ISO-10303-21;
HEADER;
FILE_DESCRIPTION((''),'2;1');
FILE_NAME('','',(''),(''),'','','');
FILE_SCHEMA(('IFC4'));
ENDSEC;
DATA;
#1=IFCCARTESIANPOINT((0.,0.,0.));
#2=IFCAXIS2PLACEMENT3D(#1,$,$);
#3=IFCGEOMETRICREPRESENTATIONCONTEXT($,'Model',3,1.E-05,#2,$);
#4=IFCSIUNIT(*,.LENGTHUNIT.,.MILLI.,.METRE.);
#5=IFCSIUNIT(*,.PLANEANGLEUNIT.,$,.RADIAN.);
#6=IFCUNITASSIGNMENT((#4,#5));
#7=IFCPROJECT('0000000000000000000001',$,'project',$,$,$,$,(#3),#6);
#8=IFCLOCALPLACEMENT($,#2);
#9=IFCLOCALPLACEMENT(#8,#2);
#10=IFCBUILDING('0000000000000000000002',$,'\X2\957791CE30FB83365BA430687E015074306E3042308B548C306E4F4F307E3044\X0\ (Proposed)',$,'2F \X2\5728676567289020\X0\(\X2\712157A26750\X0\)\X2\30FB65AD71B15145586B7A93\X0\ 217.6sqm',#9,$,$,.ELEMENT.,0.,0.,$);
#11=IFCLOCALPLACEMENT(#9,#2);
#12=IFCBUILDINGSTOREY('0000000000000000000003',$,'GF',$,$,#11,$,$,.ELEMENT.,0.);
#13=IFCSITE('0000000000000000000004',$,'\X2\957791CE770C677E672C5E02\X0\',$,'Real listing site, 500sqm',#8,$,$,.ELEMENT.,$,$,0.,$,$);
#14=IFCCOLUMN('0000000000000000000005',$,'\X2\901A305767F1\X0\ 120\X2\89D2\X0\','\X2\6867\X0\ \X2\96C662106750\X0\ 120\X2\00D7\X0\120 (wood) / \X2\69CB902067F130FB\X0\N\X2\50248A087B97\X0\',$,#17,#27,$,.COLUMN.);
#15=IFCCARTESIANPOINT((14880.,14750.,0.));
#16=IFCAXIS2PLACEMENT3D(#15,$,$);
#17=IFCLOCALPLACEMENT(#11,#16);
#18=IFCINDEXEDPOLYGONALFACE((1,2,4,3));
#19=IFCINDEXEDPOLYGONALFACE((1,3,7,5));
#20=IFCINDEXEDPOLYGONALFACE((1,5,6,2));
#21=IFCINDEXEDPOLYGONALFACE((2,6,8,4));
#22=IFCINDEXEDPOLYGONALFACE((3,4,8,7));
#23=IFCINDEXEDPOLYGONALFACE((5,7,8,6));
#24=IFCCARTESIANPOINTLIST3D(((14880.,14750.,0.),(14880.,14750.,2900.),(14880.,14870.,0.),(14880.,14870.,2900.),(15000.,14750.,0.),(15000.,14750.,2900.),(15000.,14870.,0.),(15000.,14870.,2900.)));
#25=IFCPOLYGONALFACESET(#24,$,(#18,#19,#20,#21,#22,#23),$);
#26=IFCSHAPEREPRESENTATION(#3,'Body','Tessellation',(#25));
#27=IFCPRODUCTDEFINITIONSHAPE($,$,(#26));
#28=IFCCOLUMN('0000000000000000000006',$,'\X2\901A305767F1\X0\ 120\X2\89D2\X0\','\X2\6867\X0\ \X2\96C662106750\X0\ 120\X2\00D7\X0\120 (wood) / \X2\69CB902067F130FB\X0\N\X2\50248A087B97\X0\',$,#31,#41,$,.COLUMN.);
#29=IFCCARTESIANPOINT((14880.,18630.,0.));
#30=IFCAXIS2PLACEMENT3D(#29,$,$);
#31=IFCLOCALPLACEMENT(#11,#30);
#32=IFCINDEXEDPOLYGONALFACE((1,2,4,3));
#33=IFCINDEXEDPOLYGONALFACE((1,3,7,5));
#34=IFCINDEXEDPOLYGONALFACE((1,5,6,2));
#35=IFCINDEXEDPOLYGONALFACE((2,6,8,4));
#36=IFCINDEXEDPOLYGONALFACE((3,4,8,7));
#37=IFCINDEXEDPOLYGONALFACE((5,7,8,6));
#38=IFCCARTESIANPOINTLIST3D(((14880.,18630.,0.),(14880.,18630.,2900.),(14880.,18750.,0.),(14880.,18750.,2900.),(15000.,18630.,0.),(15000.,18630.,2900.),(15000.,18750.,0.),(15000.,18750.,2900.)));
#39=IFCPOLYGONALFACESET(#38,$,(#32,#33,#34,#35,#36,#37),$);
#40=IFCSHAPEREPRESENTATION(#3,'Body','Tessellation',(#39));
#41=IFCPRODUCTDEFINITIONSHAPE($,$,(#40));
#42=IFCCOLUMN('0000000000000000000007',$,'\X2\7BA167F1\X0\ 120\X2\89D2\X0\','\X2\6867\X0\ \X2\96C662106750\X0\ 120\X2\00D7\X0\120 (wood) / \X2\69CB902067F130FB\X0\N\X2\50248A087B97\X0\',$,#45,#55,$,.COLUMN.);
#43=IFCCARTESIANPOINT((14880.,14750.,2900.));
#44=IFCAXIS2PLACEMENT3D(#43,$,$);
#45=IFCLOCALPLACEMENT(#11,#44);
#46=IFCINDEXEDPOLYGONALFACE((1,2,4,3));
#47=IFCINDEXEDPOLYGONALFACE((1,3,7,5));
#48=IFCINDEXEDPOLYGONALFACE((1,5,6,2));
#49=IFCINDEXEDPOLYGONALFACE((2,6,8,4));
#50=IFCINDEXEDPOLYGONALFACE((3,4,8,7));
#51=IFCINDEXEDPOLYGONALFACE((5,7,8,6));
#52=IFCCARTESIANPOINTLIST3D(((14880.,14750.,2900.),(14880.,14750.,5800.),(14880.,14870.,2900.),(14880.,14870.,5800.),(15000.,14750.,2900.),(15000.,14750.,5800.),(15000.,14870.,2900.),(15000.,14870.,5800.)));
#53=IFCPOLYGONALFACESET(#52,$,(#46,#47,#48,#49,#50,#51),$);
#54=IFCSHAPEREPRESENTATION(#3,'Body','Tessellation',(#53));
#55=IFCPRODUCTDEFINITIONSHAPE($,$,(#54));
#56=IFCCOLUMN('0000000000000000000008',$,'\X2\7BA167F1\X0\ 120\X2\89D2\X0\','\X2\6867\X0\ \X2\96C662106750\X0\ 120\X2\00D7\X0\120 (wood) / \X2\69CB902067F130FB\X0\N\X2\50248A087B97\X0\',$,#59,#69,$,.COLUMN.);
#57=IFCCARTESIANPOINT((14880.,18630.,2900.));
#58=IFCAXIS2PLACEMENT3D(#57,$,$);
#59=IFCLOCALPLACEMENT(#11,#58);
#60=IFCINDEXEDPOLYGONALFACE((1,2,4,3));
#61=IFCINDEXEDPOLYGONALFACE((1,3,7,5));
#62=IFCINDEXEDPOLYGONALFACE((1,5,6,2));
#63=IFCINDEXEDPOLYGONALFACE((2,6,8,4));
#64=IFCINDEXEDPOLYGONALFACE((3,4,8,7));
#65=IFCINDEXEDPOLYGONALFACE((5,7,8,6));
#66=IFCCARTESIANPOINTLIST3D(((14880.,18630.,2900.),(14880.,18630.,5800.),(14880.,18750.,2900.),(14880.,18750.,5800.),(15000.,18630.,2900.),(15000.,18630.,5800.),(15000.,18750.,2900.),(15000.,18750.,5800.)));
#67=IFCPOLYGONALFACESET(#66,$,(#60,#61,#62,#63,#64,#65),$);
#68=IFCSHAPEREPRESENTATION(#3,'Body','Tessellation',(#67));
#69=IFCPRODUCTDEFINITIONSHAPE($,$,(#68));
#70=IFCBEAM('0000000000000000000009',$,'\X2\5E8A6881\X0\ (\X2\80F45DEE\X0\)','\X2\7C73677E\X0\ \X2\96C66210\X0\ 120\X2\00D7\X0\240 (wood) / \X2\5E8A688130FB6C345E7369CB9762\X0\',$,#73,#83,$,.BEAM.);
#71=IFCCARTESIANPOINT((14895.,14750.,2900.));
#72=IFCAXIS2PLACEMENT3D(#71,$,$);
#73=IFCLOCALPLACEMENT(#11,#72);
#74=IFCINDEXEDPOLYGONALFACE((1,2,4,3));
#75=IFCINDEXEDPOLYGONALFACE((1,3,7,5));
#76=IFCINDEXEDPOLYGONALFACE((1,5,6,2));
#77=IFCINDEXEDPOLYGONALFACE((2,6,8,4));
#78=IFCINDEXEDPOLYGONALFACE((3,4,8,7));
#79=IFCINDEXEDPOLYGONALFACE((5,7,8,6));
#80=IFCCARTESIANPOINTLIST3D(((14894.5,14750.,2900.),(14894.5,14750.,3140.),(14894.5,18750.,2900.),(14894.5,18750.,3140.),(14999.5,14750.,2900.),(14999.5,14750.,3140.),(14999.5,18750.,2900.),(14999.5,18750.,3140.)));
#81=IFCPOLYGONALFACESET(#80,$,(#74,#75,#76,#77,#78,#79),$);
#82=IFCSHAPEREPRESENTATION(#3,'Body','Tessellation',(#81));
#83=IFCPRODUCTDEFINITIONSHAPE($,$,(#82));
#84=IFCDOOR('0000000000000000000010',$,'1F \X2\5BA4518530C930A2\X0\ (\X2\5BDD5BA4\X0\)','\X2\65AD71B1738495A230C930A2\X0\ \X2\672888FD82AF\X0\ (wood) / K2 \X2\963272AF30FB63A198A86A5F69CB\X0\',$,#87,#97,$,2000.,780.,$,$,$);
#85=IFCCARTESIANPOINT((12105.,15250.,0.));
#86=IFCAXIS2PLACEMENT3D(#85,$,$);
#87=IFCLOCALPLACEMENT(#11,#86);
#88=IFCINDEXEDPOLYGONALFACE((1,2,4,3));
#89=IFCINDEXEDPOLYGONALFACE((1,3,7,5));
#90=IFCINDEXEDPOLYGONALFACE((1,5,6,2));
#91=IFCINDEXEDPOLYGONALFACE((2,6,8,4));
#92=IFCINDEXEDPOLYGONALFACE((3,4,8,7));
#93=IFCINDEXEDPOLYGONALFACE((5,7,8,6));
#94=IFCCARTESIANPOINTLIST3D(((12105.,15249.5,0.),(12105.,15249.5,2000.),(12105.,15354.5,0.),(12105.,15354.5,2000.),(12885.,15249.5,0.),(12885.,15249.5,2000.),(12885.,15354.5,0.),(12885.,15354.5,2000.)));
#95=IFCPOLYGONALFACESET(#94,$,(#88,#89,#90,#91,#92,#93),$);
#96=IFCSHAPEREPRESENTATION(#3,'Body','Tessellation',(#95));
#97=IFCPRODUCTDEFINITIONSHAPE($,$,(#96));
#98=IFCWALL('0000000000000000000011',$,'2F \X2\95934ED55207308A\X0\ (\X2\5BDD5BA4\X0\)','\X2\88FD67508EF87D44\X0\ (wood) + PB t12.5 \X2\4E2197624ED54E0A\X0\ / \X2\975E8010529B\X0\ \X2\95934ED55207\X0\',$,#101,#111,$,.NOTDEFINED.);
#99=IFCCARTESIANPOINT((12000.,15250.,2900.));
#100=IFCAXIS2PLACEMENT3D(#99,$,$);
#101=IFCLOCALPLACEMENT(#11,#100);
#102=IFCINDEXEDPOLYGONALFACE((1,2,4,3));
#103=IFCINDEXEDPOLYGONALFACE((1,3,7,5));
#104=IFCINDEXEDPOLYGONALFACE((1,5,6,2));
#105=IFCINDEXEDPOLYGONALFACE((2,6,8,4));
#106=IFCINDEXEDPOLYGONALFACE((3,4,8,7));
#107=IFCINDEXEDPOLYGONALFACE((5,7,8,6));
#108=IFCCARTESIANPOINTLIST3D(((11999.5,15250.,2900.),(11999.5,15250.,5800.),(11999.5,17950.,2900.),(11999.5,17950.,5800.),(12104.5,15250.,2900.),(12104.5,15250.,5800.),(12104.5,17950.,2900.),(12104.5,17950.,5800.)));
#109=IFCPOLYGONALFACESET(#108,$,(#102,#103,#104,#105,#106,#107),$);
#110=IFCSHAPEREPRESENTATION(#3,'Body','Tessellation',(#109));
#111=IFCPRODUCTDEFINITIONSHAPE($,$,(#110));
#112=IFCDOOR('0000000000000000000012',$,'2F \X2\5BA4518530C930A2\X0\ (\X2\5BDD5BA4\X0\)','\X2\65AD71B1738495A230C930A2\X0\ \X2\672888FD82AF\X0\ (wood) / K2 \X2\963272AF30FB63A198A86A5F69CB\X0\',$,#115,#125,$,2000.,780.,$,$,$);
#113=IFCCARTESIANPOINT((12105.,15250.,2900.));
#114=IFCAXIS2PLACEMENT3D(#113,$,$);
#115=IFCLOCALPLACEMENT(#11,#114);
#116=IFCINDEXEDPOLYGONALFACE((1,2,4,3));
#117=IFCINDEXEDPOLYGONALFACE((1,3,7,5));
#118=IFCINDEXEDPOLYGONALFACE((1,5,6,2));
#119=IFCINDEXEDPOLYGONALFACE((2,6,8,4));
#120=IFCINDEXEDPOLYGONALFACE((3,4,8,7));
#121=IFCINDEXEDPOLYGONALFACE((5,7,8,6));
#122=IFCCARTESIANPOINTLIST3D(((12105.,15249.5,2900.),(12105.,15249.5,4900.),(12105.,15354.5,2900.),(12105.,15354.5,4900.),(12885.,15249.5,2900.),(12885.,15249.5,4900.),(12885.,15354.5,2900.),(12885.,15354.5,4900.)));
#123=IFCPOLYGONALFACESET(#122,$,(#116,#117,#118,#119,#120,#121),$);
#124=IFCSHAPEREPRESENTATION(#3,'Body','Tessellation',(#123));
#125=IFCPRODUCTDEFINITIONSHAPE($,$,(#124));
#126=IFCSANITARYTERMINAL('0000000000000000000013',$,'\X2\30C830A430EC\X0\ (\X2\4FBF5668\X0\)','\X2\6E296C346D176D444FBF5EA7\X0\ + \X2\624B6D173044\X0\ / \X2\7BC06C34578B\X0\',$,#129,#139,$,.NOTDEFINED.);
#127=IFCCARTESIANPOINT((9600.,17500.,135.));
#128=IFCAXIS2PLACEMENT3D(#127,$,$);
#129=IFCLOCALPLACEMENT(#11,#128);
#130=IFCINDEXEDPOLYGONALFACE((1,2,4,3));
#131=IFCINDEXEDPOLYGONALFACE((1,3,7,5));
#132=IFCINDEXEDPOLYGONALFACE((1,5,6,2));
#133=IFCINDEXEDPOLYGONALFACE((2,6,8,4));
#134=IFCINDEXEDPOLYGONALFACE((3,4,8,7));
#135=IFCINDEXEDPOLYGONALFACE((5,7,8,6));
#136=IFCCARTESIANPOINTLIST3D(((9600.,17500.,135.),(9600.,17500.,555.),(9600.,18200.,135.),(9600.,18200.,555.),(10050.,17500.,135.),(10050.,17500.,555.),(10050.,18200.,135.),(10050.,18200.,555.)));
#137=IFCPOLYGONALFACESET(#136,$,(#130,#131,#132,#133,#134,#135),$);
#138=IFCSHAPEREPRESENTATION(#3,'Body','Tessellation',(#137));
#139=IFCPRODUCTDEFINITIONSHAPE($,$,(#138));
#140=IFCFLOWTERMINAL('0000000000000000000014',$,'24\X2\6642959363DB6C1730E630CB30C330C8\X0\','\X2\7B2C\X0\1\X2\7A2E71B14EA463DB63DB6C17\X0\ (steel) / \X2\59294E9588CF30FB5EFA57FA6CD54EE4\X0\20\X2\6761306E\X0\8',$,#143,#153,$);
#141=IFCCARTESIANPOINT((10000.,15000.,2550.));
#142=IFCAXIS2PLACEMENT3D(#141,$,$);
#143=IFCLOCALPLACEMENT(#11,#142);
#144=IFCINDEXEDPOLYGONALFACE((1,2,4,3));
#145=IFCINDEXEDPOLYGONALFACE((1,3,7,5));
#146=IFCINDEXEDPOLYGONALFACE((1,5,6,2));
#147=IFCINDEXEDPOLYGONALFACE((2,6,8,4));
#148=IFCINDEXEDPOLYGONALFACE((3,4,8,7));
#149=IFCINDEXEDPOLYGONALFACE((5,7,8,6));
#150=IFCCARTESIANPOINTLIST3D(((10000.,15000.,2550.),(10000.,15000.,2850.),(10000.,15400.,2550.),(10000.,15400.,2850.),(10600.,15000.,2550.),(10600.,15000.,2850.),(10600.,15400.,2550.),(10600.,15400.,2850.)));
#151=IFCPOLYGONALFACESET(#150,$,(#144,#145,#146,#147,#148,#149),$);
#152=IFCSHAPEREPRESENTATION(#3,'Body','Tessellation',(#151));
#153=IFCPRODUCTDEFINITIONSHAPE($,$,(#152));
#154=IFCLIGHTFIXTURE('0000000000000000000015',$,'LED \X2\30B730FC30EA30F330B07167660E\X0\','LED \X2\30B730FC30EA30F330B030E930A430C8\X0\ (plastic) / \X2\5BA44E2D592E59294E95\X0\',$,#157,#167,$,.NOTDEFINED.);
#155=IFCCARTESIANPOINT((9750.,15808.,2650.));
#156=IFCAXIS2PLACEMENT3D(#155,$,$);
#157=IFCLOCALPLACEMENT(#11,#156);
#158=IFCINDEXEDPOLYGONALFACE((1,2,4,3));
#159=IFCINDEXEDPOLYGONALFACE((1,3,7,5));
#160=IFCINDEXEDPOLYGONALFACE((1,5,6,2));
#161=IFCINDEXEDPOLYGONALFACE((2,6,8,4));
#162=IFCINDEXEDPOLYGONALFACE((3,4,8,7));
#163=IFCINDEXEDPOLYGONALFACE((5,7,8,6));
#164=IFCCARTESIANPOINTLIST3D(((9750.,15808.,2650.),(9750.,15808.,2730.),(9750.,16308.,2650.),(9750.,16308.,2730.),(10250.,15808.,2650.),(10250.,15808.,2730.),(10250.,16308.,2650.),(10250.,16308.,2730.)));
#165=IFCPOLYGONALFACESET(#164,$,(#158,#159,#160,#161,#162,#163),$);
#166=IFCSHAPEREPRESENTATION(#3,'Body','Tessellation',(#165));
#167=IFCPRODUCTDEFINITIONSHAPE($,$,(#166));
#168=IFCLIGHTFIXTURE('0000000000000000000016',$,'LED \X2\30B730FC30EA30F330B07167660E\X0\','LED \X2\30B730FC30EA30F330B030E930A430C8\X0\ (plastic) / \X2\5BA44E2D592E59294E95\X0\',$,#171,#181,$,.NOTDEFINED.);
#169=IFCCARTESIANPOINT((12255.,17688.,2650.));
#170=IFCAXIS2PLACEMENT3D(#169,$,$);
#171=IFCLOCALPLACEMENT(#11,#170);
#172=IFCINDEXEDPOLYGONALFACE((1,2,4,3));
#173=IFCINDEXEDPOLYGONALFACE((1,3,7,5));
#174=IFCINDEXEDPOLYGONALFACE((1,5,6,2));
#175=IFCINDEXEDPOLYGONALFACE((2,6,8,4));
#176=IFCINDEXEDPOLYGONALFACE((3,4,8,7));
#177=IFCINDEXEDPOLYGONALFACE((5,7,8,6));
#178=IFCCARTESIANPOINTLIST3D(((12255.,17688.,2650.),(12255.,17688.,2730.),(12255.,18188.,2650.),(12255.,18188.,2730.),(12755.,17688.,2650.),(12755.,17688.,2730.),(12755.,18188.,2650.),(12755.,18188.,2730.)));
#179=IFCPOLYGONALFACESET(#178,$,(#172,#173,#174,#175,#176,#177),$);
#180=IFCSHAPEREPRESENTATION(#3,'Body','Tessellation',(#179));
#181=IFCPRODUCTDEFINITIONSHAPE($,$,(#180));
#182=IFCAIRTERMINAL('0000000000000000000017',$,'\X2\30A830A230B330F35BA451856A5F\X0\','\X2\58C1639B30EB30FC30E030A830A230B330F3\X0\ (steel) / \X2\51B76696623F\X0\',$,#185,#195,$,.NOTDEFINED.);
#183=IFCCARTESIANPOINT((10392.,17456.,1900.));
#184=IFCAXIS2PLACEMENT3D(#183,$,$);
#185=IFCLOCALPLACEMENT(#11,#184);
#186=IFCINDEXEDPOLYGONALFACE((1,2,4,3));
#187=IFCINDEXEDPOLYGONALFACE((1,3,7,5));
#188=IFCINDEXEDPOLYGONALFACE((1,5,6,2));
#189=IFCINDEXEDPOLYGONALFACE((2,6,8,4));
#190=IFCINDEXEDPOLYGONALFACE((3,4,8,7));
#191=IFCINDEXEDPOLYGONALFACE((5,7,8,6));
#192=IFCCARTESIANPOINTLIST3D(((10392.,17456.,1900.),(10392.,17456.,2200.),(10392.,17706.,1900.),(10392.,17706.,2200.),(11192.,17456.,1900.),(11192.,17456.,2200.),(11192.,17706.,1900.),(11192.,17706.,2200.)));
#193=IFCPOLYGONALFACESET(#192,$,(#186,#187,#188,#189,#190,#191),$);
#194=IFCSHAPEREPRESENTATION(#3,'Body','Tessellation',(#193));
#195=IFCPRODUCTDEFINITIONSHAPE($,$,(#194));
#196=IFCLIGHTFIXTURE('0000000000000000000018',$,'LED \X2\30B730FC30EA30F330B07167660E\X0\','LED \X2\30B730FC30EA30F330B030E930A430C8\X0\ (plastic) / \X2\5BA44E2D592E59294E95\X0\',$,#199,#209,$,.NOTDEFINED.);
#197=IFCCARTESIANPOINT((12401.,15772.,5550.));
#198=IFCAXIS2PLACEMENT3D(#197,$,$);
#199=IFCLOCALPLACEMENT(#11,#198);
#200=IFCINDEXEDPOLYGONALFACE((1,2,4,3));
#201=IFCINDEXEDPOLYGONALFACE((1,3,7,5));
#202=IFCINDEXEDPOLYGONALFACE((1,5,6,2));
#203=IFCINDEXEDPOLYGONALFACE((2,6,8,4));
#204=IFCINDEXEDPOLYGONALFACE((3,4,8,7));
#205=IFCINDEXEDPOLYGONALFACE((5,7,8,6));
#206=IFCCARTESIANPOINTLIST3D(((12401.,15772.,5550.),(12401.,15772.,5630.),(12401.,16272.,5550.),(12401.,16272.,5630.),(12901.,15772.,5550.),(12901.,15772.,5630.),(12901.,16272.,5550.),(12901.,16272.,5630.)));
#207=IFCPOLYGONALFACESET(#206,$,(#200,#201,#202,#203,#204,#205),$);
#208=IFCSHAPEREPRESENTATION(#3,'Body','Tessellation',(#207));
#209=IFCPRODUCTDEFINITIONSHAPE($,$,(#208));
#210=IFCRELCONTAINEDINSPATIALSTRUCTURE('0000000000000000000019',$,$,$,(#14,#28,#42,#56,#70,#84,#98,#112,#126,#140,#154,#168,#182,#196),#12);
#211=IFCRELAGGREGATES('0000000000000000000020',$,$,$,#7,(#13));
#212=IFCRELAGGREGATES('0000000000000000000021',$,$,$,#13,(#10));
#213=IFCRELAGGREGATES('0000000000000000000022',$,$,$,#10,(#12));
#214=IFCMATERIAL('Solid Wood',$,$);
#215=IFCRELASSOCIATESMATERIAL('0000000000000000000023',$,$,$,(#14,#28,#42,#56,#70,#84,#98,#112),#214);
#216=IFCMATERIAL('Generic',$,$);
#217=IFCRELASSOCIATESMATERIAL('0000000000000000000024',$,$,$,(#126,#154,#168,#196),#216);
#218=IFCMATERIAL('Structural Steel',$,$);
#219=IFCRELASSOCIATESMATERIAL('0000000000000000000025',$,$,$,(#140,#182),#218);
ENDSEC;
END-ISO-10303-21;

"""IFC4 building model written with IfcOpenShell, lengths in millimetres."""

from ifc_helpers import new_model, si_unit, frame, frame_2d, origin, place, context, project, spatial, rectangle, extrude, material, element, save


model = new_model("IFC4")

# Units and contexts
model_context = context("Model", 3, precision=1e-05, world=origin())
ifc_project = project(units=[si_unit("LENGTHUNIT", "METRE", prefix="MILLI"), si_unit("PLANEANGLEUNIT", "RADIAN")], contexts=[model_context])

# Site, building, storey
site_placement = place(None, origin())
site = spatial("IfcSite", under=ifc_project, at=site_placement, Name="長野県松本市", ObjectType="Real listing site, 500sqm", CompositionType="ELEMENT", RefElevation=0.0)
building_placement = place(site_placement, origin())
building = spatial("IfcBuilding", under=site, at=building_placement, Name="長野・茶室と縁側のある和の住まい (Proposed)", ObjectType="2F 在来木造(無垢材)・断熱充填窓 217.6sqm", CompositionType="ELEMENT", ElevationOfRefHeight=0.0, ElevationOfTerrain=0.0)
storey_placement = place(building_placement, origin())
storey = spatial("IfcBuildingStorey", under=building, at=storey_placement, Name="GF", CompositionType="ELEMENT", Elevation=0.0)

# Columns
ifc_material_1 = material(Name="Solid Wood")
column_1_placement = place(storey_placement, frame((14880.0, 14750.0, 0.0)))
element("IfcColumn", 1, at=column_1_placement, inside=storey, material=ifc_material_1, Name="通し柱 120角", Description="桧 集成材 120×120 (wood) / 構造柱・N値計算", PredefinedType="COLUMN", context=model_context, shape_type="SweptSolid", body=[
    extrude(rectangle(XDim=120.0, YDim=120.0, at=frame_2d((60.0, 60.0))), frame((14880.0, 14750.0, 0.0)), (0.0, 0.0, 1.0), 2900.0),
])
column_2_placement = place(storey_placement, frame((14880.0, 18630.0, 0.0)))
element("IfcColumn", 2, at=column_2_placement, inside=storey, material=ifc_material_1, Name="通し柱 120角", Description="桧 集成材 120×120 (wood) / 構造柱・N値計算", PredefinedType="COLUMN", context=model_context, shape_type="SweptSolid", body=[
    extrude(rectangle(XDim=120.0, YDim=120.0, at=frame_2d((60.0, 60.0))), frame((14880.0, 18630.0, 0.0)), (0.0, 0.0, 1.0), 2900.0),
])
column_3_placement = place(storey_placement, frame((14880.0, 14750.0, 2900.0)))
element("IfcColumn", 3, at=column_3_placement, inside=storey, material=ifc_material_1, Name="管柱 120角", Description="桧 集成材 120×120 (wood) / 構造柱・N値計算", PredefinedType="COLUMN", context=model_context, shape_type="SweptSolid", body=[
    extrude(rectangle(XDim=120.0, YDim=120.0, at=frame_2d((60.0, 60.0))), frame((14880.0, 14750.0, 2900.0)), (0.0, 0.0, 1.0), 2900.0),
])
column_4_placement = place(storey_placement, frame((14880.0, 18630.0, 2900.0)))
element("IfcColumn", 4, at=column_4_placement, inside=storey, material=ifc_material_1, Name="管柱 120角", Description="桧 集成材 120×120 (wood) / 構造柱・N値計算", PredefinedType="COLUMN", context=model_context, shape_type="SweptSolid", body=[
    extrude(rectangle(XDim=120.0, YDim=120.0, at=frame_2d((60.0, 60.0))), frame((14880.0, 18630.0, 2900.0)), (0.0, 0.0, 1.0), 2900.0),
])

# Beam
beam_1_placement = place(storey_placement, frame((14895.0, 14750.0, 2900.0)))
element("IfcBeam", 5, at=beam_1_placement, inside=storey, material=ifc_material_1, Name="床梁 (胴差)", Description="米松 集成 120×240 (wood) / 床梁・水平構面", PredefinedType="BEAM", context=model_context, shape_type="SweptSolid", body=[
    extrude(rectangle(XDim=105.0, YDim=4000.0, at=frame_2d((52.0, 2000.0))), frame((14895.0, 14750.0, 2900.0)), (0.0, 0.0, 1.0), 240.0),
])

# Door
door_1_placement = place(storey_placement, frame((12105.0, 15250.0, 0.0)))
element("IfcDoor", 6, at=door_1_placement, inside=storey, material=ifc_material_1, Name="1F 室内ドア (寝室)", Description="断熱玄関ドア 木製芯 (wood) / K2 防犯・採風機構", OverallHeight=2000.0, OverallWidth=780.0, context=model_context, shape_type="SweptSolid", body=[
    extrude(rectangle(XDim=780.0, YDim=105.0, at=frame_2d((390.0, 52.0))), frame((12105.0, 15250.0, 0.0)), (0.0, 0.0, 1.0), 2000.0),
])

# Wall
wall_1_placement = place(storey_placement, frame((12000.0, 15250.0, 2900.0)))
element("IfcWall", 7, at=wall_1_placement, inside=storey, material=ifc_material_1, Name="2F 間仕切り (寝室)", Description="製材軸組 (wood) + PB t12.5 両面仕上 / 非耐力 間仕切", PredefinedType="NOTDEFINED", context=model_context, shape_type="SweptSolid", body=[
    extrude(rectangle(XDim=105.0, YDim=2700.0, at=frame_2d((52.0, 1350.0))), frame((12000.0, 15250.0, 2900.0)), (0.0, 0.0, 1.0), 2900.0),
])

# Door
door_2_placement = place(storey_placement, frame((12105.0, 15250.0, 2900.0)))
element("IfcDoor", 8, at=door_2_placement, inside=storey, material=ifc_material_1, Name="2F 室内ドア (寝室)", Description="断熱玄関ドア 木製芯 (wood) / K2 防犯・採風機構", OverallHeight=2000.0, OverallWidth=780.0, context=model_context, shape_type="SweptSolid", body=[
    extrude(rectangle(XDim=780.0, YDim=105.0, at=frame_2d((390.0, 52.0))), frame((12105.0, 15250.0, 2900.0)), (0.0, 0.0, 1.0), 2000.0),
])

# Sanitary terminal
ifc_material_2 = material(Name="Generic")
sanitary_terminal_placement = place(storey_placement, frame((9600.0, 17500.0, 135.0)))
element("IfcSanitaryTerminal", 9, at=sanitary_terminal_placement, inside=storey, material=ifc_material_2, Name="トイレ (便器)", Description="温水洗浄便座 + 手洗い / 節水型", PredefinedType="NOTDEFINED", context=model_context, shape_type="SweptSolid", body=[
    extrude(rectangle(XDim=450.0, YDim=700.0, at=frame_2d((225.0, 350.0))), frame((9600.0, 17500.0, 135.0)), (0.0, 0.0, 1.0), 420.0),
])

# Flow terminal
ifc_material_3 = material(Name="Structural Steel")
flow_terminal_placement = place(storey_placement, frame((10000.0, 15000.0, 2550.0)))
element("IfcFlowTerminal", 10, at=flow_terminal_placement, inside=storey, material=ifc_material_3, Name="24時間換気ユニット", Description="第1種熱交換換気 (steel) / 天井裏・建基法令20条の8", context=model_context, shape_type="SweptSolid", body=[
    extrude(rectangle(XDim=600.0, YDim=400.0, at=frame_2d((300.0, 200.0))), frame((10000.0, 15000.0, 2550.0)), (0.0, 0.0, 1.0), 300.0),
])

# Light fixtures
light_fixture_1_placement = place(storey_placement, frame((9750.0, 15808.0, 2650.0)))
element("IfcLightFixture", 11, at=light_fixture_1_placement, inside=storey, material=ifc_material_2, Name="LED シーリング照明", Description="LED シーリングライト (plastic) / 室中央天井", PredefinedType="NOTDEFINED", context=model_context, shape_type="SweptSolid", body=[
    extrude(rectangle(XDim=500.0, YDim=500.0, at=frame_2d((250.0, 250.0))), frame((9750.0, 15808.0, 2650.0)), (0.0, 0.0, 1.0), 80.0),
])
light_fixture_2_placement = place(storey_placement, frame((12255.0, 17688.0, 2650.0)))
element("IfcLightFixture", 12, at=light_fixture_2_placement, inside=storey, material=ifc_material_2, Name="LED シーリング照明", Description="LED シーリングライト (plastic) / 室中央天井", PredefinedType="NOTDEFINED", context=model_context, shape_type="SweptSolid", body=[
    extrude(rectangle(XDim=500.0, YDim=500.0, at=frame_2d((250.0, 250.0))), frame((12255.0, 17688.0, 2650.0)), (0.0, 0.0, 1.0), 80.0),
])

# Air terminal
air_terminal_1_placement = place(storey_placement, frame((10392.0, 17456.0, 1900.0)))
element("IfcAirTerminal", 13, at=air_terminal_1_placement, inside=storey, material=ifc_material_3, Name="エアコン室内機", Description="壁掛ルームエアコン (steel) / 冷暖房", PredefinedType="NOTDEFINED", context=model_context, shape_type="SweptSolid", body=[
    extrude(rectangle(XDim=800.0, YDim=250.0, at=frame_2d((400.0, 125.0))), frame((10392.0, 17456.0, 1900.0)), (0.0, 0.0, 1.0), 300.0),
])

# Light fixture
light_fixture_3_placement = place(storey_placement, frame((12401.0, 15772.0, 5550.0)))
element("IfcLightFixture", 14, at=light_fixture_3_placement, inside=storey, material=ifc_material_2, Name="LED シーリング照明", Description="LED シーリングライト (plastic) / 室中央天井", PredefinedType="NOTDEFINED", context=model_context, shape_type="SweptSolid", body=[
    extrude(rectangle(XDim=500.0, YDim=500.0, at=frame_2d((250.0, 250.0))), frame((12401.0, 15772.0, 5550.0)), (0.0, 0.0, 1.0), 80.0),
])

save(model, "model.ifc")
